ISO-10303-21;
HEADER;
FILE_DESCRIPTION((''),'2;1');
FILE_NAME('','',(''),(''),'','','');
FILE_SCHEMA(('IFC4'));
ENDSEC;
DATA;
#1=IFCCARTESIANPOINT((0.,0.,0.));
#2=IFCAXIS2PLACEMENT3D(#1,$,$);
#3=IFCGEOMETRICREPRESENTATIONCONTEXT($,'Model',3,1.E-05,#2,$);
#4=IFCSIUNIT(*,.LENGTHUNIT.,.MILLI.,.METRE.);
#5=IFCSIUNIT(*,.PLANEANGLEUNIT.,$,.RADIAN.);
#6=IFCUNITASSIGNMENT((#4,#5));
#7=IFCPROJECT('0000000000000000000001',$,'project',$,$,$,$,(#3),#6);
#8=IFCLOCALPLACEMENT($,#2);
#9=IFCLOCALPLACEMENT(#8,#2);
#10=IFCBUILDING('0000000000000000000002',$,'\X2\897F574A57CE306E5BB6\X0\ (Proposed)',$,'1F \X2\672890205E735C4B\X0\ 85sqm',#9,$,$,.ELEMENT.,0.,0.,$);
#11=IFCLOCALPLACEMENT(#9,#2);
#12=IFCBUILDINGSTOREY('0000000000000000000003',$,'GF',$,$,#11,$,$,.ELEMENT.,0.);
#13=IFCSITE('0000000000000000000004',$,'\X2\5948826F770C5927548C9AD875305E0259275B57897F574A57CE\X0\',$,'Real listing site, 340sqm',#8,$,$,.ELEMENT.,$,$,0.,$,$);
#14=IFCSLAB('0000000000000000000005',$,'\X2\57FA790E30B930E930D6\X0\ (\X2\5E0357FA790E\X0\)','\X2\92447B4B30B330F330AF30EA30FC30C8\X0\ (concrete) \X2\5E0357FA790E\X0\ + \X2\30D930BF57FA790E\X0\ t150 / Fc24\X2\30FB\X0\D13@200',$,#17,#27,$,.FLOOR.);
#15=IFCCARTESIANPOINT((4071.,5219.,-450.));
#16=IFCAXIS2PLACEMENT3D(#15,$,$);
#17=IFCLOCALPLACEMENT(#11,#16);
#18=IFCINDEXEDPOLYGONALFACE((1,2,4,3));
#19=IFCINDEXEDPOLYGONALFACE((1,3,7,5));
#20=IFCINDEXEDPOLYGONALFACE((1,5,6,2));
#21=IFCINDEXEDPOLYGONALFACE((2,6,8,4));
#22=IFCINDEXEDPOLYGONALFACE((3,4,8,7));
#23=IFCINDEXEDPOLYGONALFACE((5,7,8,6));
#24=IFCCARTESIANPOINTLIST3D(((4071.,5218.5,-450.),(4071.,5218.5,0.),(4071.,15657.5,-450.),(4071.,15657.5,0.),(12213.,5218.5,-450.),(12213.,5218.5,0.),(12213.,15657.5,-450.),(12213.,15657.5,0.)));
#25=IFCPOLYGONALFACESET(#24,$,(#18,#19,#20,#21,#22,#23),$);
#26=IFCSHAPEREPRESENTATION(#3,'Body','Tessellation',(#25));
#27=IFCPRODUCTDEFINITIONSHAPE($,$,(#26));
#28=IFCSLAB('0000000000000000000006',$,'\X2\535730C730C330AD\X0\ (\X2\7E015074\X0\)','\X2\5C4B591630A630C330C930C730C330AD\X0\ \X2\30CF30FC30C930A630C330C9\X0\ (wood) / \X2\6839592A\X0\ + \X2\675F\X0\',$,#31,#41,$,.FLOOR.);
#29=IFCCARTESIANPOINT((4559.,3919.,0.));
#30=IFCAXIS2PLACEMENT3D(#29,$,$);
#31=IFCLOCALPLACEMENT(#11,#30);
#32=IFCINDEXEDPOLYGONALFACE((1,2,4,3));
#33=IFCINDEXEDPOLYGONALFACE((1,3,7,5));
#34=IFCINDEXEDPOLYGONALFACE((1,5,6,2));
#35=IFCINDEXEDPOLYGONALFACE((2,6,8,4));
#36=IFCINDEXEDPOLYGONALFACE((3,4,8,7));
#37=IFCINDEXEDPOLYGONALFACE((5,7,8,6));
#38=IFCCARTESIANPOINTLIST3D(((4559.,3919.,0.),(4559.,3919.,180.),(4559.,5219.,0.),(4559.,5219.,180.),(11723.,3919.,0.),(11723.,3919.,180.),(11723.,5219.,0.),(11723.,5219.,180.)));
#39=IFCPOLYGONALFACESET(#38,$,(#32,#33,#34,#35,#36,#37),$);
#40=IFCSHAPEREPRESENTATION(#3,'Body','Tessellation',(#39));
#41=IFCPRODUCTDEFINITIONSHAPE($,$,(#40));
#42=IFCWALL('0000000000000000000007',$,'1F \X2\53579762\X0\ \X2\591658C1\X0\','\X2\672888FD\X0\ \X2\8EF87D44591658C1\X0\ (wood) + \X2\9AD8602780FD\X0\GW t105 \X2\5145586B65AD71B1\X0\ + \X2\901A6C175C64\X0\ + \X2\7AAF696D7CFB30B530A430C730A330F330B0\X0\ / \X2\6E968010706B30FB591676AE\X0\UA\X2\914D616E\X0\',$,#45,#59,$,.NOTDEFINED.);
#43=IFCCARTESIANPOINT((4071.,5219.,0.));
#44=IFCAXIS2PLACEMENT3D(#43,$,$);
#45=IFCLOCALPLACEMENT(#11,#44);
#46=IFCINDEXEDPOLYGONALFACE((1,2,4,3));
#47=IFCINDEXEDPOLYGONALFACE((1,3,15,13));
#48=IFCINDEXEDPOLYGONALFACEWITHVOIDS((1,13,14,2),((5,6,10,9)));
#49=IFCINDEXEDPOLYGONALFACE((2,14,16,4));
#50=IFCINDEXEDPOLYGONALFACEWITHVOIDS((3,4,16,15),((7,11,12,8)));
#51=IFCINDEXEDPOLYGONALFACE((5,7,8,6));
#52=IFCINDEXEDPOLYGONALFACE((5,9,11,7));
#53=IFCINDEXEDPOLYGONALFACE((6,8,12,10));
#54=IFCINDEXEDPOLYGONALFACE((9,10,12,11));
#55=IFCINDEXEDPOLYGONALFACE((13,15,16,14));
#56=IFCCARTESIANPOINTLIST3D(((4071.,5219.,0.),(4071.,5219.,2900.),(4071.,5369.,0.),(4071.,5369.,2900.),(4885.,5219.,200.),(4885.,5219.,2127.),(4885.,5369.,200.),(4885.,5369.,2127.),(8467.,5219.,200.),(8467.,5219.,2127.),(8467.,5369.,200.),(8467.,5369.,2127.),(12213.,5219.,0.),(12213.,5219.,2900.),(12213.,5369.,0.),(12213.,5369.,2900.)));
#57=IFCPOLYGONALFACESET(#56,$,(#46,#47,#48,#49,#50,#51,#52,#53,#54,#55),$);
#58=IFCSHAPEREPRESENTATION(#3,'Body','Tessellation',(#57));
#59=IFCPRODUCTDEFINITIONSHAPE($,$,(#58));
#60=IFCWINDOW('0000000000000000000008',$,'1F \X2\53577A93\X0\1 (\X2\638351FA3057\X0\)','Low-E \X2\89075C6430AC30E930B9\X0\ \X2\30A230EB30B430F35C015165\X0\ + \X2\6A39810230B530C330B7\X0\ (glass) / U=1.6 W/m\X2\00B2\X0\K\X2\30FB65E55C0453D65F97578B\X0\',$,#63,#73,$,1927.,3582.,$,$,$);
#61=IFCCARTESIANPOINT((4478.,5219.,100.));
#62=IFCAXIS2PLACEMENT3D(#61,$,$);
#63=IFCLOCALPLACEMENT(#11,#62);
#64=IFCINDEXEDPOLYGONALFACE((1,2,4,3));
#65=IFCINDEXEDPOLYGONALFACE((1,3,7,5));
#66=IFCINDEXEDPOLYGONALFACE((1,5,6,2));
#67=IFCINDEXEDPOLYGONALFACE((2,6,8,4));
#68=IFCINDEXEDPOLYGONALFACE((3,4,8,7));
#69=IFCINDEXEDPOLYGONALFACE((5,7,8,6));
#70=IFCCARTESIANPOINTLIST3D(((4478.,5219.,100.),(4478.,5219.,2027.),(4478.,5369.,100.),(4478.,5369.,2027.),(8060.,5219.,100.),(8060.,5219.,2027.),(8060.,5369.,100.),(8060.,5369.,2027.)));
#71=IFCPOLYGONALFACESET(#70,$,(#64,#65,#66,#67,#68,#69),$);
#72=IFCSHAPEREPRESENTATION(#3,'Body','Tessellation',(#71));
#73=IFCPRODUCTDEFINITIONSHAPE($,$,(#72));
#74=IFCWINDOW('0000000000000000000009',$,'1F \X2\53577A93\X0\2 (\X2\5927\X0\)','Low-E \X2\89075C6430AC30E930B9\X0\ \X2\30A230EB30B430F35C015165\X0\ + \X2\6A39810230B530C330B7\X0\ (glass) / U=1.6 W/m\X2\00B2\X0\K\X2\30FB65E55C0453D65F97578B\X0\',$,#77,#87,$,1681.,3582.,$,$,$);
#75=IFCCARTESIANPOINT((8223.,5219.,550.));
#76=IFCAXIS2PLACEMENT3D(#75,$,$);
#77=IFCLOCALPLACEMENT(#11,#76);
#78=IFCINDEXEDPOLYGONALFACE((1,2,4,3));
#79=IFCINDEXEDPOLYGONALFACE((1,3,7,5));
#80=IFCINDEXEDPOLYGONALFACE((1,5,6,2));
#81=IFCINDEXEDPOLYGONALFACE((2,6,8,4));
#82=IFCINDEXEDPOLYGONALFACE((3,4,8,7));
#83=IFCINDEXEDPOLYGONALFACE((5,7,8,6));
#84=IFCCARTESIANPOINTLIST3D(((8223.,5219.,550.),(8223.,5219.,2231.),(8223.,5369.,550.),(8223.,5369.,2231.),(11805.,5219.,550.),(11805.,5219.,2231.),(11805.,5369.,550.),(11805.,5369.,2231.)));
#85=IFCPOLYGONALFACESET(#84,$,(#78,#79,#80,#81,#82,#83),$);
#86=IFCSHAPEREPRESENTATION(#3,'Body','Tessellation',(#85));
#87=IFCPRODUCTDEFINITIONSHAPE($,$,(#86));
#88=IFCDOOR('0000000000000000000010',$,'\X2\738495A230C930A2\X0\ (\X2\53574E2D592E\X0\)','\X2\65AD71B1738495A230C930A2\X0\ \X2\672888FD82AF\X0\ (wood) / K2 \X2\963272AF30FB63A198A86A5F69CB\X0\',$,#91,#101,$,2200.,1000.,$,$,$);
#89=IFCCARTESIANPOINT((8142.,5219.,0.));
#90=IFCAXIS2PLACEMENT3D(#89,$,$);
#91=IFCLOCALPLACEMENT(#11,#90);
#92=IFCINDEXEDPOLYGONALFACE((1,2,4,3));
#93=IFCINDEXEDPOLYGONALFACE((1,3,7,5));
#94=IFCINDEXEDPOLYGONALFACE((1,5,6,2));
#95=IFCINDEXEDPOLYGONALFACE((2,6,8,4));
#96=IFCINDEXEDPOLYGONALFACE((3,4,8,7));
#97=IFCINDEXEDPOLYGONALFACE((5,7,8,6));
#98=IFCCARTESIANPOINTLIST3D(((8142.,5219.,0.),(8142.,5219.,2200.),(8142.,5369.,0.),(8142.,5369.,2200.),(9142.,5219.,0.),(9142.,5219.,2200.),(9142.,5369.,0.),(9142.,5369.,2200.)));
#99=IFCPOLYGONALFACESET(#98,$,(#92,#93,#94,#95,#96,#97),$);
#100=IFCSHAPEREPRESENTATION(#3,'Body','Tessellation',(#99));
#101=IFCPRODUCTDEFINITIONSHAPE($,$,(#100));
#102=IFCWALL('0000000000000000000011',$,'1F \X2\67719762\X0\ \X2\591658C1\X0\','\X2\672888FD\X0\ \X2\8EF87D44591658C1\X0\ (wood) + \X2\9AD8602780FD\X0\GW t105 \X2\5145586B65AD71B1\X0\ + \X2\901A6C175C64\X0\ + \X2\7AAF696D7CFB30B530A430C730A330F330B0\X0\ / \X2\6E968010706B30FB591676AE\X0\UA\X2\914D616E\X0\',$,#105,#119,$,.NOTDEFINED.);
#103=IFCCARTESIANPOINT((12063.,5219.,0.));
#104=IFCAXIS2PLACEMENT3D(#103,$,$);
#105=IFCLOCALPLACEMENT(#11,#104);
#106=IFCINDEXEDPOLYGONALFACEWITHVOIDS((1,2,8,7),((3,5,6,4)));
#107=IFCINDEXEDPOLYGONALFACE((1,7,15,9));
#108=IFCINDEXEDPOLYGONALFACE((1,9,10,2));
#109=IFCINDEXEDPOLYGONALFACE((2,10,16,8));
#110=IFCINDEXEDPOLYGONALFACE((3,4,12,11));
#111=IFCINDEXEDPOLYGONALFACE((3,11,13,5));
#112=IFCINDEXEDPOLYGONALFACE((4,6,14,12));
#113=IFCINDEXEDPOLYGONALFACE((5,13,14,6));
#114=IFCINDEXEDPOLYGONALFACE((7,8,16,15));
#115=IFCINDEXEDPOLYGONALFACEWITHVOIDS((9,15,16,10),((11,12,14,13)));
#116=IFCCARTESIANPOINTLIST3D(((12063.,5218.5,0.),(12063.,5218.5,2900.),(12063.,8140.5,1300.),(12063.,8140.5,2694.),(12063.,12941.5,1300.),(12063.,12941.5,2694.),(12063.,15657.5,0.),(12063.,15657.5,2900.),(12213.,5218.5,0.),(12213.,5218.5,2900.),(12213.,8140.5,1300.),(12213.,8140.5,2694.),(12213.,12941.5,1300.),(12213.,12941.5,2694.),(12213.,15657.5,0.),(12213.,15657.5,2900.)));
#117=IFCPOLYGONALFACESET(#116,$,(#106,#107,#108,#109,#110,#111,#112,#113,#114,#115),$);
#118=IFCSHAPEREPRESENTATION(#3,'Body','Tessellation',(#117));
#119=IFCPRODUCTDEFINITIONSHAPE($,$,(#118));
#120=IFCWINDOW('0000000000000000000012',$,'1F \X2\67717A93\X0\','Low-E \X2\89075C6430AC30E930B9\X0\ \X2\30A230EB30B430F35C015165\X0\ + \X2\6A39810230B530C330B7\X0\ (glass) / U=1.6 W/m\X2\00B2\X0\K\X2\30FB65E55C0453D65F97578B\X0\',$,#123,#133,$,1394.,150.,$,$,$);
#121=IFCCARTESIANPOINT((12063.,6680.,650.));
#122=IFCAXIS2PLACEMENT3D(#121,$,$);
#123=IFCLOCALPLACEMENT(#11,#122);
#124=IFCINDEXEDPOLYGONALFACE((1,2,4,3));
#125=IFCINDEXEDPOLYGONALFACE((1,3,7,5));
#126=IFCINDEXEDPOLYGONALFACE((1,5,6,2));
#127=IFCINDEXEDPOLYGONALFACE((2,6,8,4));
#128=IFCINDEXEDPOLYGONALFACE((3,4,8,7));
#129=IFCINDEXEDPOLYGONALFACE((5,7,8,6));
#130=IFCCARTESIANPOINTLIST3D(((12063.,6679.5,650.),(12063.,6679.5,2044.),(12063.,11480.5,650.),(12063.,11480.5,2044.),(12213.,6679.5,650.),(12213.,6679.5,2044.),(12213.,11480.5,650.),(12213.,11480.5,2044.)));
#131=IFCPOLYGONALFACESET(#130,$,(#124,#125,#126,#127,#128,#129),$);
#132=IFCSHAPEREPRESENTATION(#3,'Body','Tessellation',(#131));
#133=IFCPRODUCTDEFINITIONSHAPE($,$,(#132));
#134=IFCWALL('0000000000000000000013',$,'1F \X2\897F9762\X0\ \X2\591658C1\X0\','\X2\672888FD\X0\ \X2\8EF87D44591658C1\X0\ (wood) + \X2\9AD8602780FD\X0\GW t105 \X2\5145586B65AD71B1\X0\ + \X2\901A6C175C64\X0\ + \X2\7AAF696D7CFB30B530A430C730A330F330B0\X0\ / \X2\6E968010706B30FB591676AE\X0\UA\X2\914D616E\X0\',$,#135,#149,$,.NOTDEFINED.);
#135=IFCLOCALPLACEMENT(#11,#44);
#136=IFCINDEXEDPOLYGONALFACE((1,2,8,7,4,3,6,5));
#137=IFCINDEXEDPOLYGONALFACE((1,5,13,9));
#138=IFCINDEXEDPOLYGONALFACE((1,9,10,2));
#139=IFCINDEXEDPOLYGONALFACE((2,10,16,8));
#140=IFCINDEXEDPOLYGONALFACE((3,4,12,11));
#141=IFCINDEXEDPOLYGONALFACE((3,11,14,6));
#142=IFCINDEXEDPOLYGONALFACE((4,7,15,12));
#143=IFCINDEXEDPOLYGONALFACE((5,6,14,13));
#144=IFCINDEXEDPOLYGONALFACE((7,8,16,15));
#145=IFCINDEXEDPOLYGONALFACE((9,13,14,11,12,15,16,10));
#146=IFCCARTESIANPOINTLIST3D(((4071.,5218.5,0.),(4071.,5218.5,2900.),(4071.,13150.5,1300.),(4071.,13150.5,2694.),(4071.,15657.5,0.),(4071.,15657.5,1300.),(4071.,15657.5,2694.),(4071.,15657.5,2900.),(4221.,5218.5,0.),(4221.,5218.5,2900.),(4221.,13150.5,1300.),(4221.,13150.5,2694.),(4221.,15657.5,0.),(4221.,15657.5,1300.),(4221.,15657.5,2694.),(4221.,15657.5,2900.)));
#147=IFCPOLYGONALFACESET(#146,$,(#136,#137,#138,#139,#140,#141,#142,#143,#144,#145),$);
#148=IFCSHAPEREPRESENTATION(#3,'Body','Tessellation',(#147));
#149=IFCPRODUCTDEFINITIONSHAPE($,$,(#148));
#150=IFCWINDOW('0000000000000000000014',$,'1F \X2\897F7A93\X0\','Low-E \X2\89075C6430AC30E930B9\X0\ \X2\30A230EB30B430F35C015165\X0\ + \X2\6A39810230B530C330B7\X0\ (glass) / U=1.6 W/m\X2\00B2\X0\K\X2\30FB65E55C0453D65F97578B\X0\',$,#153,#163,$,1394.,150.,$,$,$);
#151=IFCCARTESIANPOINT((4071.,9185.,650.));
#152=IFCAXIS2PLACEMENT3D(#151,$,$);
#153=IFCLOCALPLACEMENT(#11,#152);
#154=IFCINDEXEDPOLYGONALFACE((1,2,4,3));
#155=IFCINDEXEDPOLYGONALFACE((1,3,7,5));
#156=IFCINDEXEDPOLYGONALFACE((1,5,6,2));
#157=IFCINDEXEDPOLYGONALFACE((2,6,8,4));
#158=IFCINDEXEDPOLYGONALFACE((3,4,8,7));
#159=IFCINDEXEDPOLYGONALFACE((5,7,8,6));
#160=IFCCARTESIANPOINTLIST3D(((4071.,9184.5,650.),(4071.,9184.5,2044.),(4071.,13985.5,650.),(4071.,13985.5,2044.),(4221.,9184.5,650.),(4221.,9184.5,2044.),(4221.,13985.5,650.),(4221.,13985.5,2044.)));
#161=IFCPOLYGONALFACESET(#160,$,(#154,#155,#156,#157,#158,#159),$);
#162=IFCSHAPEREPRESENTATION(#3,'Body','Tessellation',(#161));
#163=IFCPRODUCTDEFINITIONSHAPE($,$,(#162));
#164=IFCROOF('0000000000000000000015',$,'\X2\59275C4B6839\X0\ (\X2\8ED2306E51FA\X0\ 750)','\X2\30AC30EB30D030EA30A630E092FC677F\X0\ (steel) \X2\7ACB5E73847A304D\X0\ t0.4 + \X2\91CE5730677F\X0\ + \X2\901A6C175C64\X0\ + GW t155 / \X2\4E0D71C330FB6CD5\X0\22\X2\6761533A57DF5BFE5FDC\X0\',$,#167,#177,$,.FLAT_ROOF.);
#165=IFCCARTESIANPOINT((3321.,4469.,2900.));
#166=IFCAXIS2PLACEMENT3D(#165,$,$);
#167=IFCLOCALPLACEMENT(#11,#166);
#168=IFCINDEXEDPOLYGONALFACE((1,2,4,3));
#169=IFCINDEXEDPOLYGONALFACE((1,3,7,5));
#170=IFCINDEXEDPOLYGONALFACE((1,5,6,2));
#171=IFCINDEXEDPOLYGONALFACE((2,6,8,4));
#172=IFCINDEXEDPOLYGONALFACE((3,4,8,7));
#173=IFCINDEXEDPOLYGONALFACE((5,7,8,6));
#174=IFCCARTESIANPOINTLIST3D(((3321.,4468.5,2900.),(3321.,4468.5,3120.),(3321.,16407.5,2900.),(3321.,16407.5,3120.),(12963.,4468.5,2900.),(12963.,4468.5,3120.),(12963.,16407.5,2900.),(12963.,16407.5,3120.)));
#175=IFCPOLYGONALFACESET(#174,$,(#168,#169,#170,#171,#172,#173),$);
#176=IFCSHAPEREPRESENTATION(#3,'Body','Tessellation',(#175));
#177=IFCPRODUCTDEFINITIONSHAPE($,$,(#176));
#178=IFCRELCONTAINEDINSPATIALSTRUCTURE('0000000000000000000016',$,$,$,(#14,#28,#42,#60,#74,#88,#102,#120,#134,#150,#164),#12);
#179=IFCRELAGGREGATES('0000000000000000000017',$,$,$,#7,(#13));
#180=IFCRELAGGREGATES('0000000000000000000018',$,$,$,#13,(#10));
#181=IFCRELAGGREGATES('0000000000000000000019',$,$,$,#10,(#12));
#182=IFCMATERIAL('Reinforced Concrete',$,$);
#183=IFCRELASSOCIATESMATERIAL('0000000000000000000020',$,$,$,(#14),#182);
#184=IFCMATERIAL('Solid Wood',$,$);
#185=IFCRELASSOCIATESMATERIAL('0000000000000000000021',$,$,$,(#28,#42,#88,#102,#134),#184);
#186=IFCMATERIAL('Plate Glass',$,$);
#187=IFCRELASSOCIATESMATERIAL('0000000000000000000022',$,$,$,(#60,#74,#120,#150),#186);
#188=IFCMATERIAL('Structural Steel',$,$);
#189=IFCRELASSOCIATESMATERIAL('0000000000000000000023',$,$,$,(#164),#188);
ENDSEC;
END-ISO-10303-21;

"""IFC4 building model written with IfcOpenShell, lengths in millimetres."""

from ifc_helpers import new_model, si_unit, frame, frame_2d, origin, place, context, project, spatial, rectangle, extrude, material, element, fill, save


model = new_model("IFC4")

# Units and contexts
model_context = context("Model", 3, precision=1e-05, world=origin())
ifc_project = project(units=[si_unit("LENGTHUNIT", "METRE", prefix="MILLI"), si_unit("PLANEANGLEUNIT", "RADIAN")], contexts=[model_context])

# Site, building, storey
site_placement = place(None, origin())
site = spatial("IfcSite", under=ifc_project, at=site_placement, Name="奈良県大和高田市大字西坊城", ObjectType="Real listing site, 340sqm", CompositionType="ELEMENT", RefElevation=0.0)
building_placement = place(site_placement, origin())
building = spatial("IfcBuilding", under=site, at=building_placement, Name="西坊城の家 (Proposed)", ObjectType="1F 木造平屋 85sqm", CompositionType="ELEMENT", ElevationOfRefHeight=0.0, ElevationOfTerrain=0.0)
storey_placement = place(building_placement, origin())
storey = spatial("IfcBuildingStorey", under=building, at=storey_placement, Name="GF", CompositionType="ELEMENT", Elevation=0.0)

# Slabs
ifc_material_1 = material(Name="Reinforced Concrete")
slab_1_placement = place(storey_placement, frame((4071.0, 5219.0, -450.0)))
element("IfcSlab", 1, at=slab_1_placement, inside=storey, material=ifc_material_1, Name="基礎スラブ (布基礎)", Description="鉄筋コンクリート (concrete) 布基礎 + ベタ基礎 t150 / Fc24・D13@200", PredefinedType="FLOOR", context=model_context, shape_type="SweptSolid", body=[
    extrude(rectangle(XDim=8142.0, YDim=10439.0, at=frame_2d((4071.0, 5219.0))), frame((4071.0, 5219.0, -450.0)), (0.0, 0.0, 1.0), 450.0),
])
ifc_material_2 = material(Name="Solid Wood")
slab_2_placement = place(storey_placement, frame((4559.0, 3919.0, 0.0)))
element("IfcSlab", 2, at=slab_2_placement, inside=storey, material=ifc_material_2, Name="南デッキ (縁側)", Description="屋外ウッドデッキ ハードウッド (wood) / 根太 + 束", PredefinedType="FLOOR", context=model_context, shape_type="SweptSolid", body=[
    extrude(rectangle(XDim=7164.0, YDim=1300.0, at=frame_2d((3582.0, 650.0))), frame((4559.0, 3919.0, 0.0)), (0.0, 0.0, 1.0), 180.0),
])

# Wall, openings, windows, door
wall_1_placement = place(storey_placement, frame((4071.0, 5219.0, 0.0)))
wall_1 = element("IfcWall", 3, at=wall_1_placement, inside=storey, material=ifc_material_2, Name="1F 南面 外壁", Description="木製 軸組外壁 (wood) + 高性能GW t105 充填断熱 + 通気層 + 窯業系サイディング / 準耐火・外皮UA配慮", PredefinedType="NOTDEFINED", context=model_context, shape_type="SweptSolid", body=[
    extrude(rectangle(XDim=8142.0, YDim=150.0, at=frame_2d((4071.0, 75.0))), frame((4071.0, 5219.0, 0.0)), (0.0, 0.0, 1.0), 2900.0),
])
opening_1_placement = place(storey_placement, frame((4478.0, 5219.0, 100.0)))
opening_1 = element("IfcOpeningElement", 4, at=opening_1_placement, cuts=wall_1, PredefinedType="NOTDEFINED", context=model_context, shape_type="SweptSolid", body=[
    extrude(rectangle(XDim=3582.0, YDim=150.0, at=frame_2d((1791.0, 75.0))), frame((4478.0, 5219.0, 100.0)), (0.0, 0.0, 1.0), 1927.0),
])
opening_2_placement = place(storey_placement, frame((8223.0, 5219.0, 550.0)))
opening_2 = element("IfcOpeningElement", 5, at=opening_2_placement, cuts=wall_1, PredefinedType="NOTDEFINED", context=model_context, shape_type="SweptSolid", body=[
    extrude(rectangle(XDim=3582.0, YDim=150.0, at=frame_2d((1791.0, 75.0))), frame((8223.0, 5219.0, 550.0)), (0.0, 0.0, 1.0), 1681.0),
])
opening_3_placement = place(storey_placement, frame((8142.0, 5219.0, 0.0)))
opening_3 = element("IfcOpeningElement", 6, at=opening_3_placement, cuts=wall_1, PredefinedType="NOTDEFINED", context=model_context, shape_type="SweptSolid", body=[
    extrude(rectangle(XDim=1000.0, YDim=150.0, at=frame_2d((500.0, 75.0))), frame((8142.0, 5219.0, 0.0)), (0.0, 0.0, 1.0), 2200.0),
])
ifc_material_3 = material(Name="Plate Glass")
window_1_placement = place(storey_placement, frame((4478.0, 5219.0, 100.0)))
window_1 = element("IfcWindow", 7, at=window_1_placement, inside=storey, material=ifc_material_3, Name="1F 南窓1 (掃出し)", Description="Low-E 複層ガラス アルゴン封入 + 樹脂サッシ (glass) / U=1.6 W/m²K・日射取得型", OverallHeight=1927.0, OverallWidth=3582.0, context=model_context, shape_type="SweptSolid", body=[
    extrude(rectangle(XDim=3582.0, YDim=150.0, at=frame_2d((1791.0, 75.0))), frame((4478.0, 5219.0, 100.0)), (0.0, 0.0, 1.0), 1927.0),
])
fill(opening_1, window_1)
window_2_placement = place(storey_placement, frame((8223.0, 5219.0, 550.0)))
window_2 = element("IfcWindow", 8, at=window_2_placement, inside=storey, material=ifc_material_3, Name="1F 南窓2 (大)", Description="Low-E 複層ガラス アルゴン封入 + 樹脂サッシ (glass) / U=1.6 W/m²K・日射取得型", OverallHeight=1681.0, OverallWidth=3582.0, context=model_context, shape_type="SweptSolid", body=[
    extrude(rectangle(XDim=3582.0, YDim=150.0, at=frame_2d((1791.0, 75.0))), frame((8223.0, 5219.0, 550.0)), (0.0, 0.0, 1.0), 1681.0),
])
fill(opening_2, window_2)
door_placement = place(storey_placement, frame((8142.0, 5219.0, 0.0)))
door = element("IfcDoor", 9, at=door_placement, inside=storey, material=ifc_material_2, Name="玄関ドア (南中央)", Description="断熱玄関ドア 木製芯 (wood) / K2 防犯・採風機構", OverallHeight=2200.0, OverallWidth=1000.0, context=model_context, shape_type="SweptSolid", body=[
    extrude(rectangle(XDim=1000.0, YDim=150.0, at=frame_2d((500.0, 75.0))), frame((8142.0, 5219.0, 0.0)), (0.0, 0.0, 1.0), 2200.0),
])
fill(opening_3, door)

# Walls, openings, windows
wall_2_placement = place(storey_placement, frame((12063.0, 5219.0, 0.0)))
wall_2 = element("IfcWall", 10, at=wall_2_placement, inside=storey, material=ifc_material_2, Name="1F 東面 外壁", Description="木製 軸組外壁 (wood) + 高性能GW t105 充填断熱 + 通気層 + 窯業系サイディング / 準耐火・外皮UA配慮", PredefinedType="NOTDEFINED", context=model_context, shape_type="SweptSolid", body=[
    extrude(rectangle(XDim=150.0, YDim=10439.0, at=frame_2d((75.0, 5219.0))), frame((12063.0, 5219.0, 0.0)), (0.0, 0.0, 1.0), 2900.0),
])
opening_4_placement = place(storey_placement, frame((12063.0, 6680.0, 650.0)))
opening_4 = element("IfcOpeningElement", 11, at=opening_4_placement, cuts=wall_2, PredefinedType="NOTDEFINED", context=model_context, shape_type="SweptSolid", body=[
    extrude(rectangle(XDim=150.0, YDim=4801.0, at=frame_2d((75.0, 2400.0))), frame((12063.0, 6680.0, 650.0)), (0.0, 0.0, 1.0), 1394.0),
])
window_3_placement = place(storey_placement, frame((12063.0, 6680.0, 650.0)))
window_3 = element("IfcWindow", 12, at=window_3_placement, inside=storey, material=ifc_material_3, Name="1F 東窓", Description="Low-E 複層ガラス アルゴン封入 + 樹脂サッシ (glass) / U=1.6 W/m²K・日射取得型", OverallHeight=1394.0, OverallWidth=150.0, context=model_context, shape_type="SweptSolid", body=[
    extrude(rectangle(XDim=150.0, YDim=4801.0, at=frame_2d((75.0, 2400.0))), frame((12063.0, 6680.0, 650.0)), (0.0, 0.0, 1.0), 1394.0),
])
fill(opening_4, window_3)
wall_3_placement = place(storey_placement, frame((4071.0, 5219.0, 0.0)))
wall_3 = element("IfcWall", 13, at=wall_3_placement, inside=storey, material=ifc_material_2, Name="1F 西面 外壁", Description="木製 軸組外壁 (wood) + 高性能GW t105 充填断熱 + 通気層 + 窯業系サイディング / 準耐火・外皮UA配慮", PredefinedType="NOTDEFINED", context=model_context, shape_type="SweptSolid", body=[
    extrude(rectangle(XDim=150.0, YDim=10439.0, at=frame_2d((75.0, 5219.0))), frame((4071.0, 5219.0, 0.0)), (0.0, 0.0, 1.0), 2900.0),
])
opening_5_placement = place(storey_placement, frame((4071.0, 9185.0, 650.0)))
opening_5 = element("IfcOpeningElement", 14, at=opening_5_placement, cuts=wall_3, PredefinedType="NOTDEFINED", context=model_context, shape_type="SweptSolid", body=[
    extrude(rectangle(XDim=150.0, YDim=4801.0, at=frame_2d((75.0, 2400.0))), frame((4071.0, 9185.0, 650.0)), (0.0, 0.0, 1.0), 1394.0),
])
window_4_placement = place(storey_placement, frame((4071.0, 9185.0, 650.0)))
window_4 = element("IfcWindow", 15, at=window_4_placement, inside=storey, material=ifc_material_3, Name="1F 西窓", Description="Low-E 複層ガラス アルゴン封入 + 樹脂サッシ (glass) / U=1.6 W/m²K・日射取得型", OverallHeight=1394.0, OverallWidth=150.0, context=model_context, shape_type="SweptSolid", body=[
    extrude(rectangle(XDim=150.0, YDim=4801.0, at=frame_2d((75.0, 2400.0))), frame((4071.0, 9185.0, 650.0)), (0.0, 0.0, 1.0), 1394.0),
])
fill(opening_5, window_4)

# Roof
ifc_material_4 = material(Name="Structural Steel")
roof_placement = place(storey_placement, frame((3321.0, 4469.0, 2900.0)))
element("IfcRoof", 16, at=roof_placement, inside=storey, material=ifc_material_4, Name="大屋根 (軒の出 750)", Description="ガルバリウム鋼板 (steel) 立平葺き t0.4 + 野地板 + 通気層 + GW t155 / 不燃・法22条区域対応", PredefinedType="FLAT_ROOF", context=model_context, shape_type="SweptSolid", body=[
    extrude(rectangle(XDim=9642.0, YDim=11939.0, at=frame_2d((4821.0, 5969.0))), frame((3321.0, 4469.0, 2900.0)), (0.0, 0.0, 1.0), 220.0),
])

save(model, "model.ifc")
